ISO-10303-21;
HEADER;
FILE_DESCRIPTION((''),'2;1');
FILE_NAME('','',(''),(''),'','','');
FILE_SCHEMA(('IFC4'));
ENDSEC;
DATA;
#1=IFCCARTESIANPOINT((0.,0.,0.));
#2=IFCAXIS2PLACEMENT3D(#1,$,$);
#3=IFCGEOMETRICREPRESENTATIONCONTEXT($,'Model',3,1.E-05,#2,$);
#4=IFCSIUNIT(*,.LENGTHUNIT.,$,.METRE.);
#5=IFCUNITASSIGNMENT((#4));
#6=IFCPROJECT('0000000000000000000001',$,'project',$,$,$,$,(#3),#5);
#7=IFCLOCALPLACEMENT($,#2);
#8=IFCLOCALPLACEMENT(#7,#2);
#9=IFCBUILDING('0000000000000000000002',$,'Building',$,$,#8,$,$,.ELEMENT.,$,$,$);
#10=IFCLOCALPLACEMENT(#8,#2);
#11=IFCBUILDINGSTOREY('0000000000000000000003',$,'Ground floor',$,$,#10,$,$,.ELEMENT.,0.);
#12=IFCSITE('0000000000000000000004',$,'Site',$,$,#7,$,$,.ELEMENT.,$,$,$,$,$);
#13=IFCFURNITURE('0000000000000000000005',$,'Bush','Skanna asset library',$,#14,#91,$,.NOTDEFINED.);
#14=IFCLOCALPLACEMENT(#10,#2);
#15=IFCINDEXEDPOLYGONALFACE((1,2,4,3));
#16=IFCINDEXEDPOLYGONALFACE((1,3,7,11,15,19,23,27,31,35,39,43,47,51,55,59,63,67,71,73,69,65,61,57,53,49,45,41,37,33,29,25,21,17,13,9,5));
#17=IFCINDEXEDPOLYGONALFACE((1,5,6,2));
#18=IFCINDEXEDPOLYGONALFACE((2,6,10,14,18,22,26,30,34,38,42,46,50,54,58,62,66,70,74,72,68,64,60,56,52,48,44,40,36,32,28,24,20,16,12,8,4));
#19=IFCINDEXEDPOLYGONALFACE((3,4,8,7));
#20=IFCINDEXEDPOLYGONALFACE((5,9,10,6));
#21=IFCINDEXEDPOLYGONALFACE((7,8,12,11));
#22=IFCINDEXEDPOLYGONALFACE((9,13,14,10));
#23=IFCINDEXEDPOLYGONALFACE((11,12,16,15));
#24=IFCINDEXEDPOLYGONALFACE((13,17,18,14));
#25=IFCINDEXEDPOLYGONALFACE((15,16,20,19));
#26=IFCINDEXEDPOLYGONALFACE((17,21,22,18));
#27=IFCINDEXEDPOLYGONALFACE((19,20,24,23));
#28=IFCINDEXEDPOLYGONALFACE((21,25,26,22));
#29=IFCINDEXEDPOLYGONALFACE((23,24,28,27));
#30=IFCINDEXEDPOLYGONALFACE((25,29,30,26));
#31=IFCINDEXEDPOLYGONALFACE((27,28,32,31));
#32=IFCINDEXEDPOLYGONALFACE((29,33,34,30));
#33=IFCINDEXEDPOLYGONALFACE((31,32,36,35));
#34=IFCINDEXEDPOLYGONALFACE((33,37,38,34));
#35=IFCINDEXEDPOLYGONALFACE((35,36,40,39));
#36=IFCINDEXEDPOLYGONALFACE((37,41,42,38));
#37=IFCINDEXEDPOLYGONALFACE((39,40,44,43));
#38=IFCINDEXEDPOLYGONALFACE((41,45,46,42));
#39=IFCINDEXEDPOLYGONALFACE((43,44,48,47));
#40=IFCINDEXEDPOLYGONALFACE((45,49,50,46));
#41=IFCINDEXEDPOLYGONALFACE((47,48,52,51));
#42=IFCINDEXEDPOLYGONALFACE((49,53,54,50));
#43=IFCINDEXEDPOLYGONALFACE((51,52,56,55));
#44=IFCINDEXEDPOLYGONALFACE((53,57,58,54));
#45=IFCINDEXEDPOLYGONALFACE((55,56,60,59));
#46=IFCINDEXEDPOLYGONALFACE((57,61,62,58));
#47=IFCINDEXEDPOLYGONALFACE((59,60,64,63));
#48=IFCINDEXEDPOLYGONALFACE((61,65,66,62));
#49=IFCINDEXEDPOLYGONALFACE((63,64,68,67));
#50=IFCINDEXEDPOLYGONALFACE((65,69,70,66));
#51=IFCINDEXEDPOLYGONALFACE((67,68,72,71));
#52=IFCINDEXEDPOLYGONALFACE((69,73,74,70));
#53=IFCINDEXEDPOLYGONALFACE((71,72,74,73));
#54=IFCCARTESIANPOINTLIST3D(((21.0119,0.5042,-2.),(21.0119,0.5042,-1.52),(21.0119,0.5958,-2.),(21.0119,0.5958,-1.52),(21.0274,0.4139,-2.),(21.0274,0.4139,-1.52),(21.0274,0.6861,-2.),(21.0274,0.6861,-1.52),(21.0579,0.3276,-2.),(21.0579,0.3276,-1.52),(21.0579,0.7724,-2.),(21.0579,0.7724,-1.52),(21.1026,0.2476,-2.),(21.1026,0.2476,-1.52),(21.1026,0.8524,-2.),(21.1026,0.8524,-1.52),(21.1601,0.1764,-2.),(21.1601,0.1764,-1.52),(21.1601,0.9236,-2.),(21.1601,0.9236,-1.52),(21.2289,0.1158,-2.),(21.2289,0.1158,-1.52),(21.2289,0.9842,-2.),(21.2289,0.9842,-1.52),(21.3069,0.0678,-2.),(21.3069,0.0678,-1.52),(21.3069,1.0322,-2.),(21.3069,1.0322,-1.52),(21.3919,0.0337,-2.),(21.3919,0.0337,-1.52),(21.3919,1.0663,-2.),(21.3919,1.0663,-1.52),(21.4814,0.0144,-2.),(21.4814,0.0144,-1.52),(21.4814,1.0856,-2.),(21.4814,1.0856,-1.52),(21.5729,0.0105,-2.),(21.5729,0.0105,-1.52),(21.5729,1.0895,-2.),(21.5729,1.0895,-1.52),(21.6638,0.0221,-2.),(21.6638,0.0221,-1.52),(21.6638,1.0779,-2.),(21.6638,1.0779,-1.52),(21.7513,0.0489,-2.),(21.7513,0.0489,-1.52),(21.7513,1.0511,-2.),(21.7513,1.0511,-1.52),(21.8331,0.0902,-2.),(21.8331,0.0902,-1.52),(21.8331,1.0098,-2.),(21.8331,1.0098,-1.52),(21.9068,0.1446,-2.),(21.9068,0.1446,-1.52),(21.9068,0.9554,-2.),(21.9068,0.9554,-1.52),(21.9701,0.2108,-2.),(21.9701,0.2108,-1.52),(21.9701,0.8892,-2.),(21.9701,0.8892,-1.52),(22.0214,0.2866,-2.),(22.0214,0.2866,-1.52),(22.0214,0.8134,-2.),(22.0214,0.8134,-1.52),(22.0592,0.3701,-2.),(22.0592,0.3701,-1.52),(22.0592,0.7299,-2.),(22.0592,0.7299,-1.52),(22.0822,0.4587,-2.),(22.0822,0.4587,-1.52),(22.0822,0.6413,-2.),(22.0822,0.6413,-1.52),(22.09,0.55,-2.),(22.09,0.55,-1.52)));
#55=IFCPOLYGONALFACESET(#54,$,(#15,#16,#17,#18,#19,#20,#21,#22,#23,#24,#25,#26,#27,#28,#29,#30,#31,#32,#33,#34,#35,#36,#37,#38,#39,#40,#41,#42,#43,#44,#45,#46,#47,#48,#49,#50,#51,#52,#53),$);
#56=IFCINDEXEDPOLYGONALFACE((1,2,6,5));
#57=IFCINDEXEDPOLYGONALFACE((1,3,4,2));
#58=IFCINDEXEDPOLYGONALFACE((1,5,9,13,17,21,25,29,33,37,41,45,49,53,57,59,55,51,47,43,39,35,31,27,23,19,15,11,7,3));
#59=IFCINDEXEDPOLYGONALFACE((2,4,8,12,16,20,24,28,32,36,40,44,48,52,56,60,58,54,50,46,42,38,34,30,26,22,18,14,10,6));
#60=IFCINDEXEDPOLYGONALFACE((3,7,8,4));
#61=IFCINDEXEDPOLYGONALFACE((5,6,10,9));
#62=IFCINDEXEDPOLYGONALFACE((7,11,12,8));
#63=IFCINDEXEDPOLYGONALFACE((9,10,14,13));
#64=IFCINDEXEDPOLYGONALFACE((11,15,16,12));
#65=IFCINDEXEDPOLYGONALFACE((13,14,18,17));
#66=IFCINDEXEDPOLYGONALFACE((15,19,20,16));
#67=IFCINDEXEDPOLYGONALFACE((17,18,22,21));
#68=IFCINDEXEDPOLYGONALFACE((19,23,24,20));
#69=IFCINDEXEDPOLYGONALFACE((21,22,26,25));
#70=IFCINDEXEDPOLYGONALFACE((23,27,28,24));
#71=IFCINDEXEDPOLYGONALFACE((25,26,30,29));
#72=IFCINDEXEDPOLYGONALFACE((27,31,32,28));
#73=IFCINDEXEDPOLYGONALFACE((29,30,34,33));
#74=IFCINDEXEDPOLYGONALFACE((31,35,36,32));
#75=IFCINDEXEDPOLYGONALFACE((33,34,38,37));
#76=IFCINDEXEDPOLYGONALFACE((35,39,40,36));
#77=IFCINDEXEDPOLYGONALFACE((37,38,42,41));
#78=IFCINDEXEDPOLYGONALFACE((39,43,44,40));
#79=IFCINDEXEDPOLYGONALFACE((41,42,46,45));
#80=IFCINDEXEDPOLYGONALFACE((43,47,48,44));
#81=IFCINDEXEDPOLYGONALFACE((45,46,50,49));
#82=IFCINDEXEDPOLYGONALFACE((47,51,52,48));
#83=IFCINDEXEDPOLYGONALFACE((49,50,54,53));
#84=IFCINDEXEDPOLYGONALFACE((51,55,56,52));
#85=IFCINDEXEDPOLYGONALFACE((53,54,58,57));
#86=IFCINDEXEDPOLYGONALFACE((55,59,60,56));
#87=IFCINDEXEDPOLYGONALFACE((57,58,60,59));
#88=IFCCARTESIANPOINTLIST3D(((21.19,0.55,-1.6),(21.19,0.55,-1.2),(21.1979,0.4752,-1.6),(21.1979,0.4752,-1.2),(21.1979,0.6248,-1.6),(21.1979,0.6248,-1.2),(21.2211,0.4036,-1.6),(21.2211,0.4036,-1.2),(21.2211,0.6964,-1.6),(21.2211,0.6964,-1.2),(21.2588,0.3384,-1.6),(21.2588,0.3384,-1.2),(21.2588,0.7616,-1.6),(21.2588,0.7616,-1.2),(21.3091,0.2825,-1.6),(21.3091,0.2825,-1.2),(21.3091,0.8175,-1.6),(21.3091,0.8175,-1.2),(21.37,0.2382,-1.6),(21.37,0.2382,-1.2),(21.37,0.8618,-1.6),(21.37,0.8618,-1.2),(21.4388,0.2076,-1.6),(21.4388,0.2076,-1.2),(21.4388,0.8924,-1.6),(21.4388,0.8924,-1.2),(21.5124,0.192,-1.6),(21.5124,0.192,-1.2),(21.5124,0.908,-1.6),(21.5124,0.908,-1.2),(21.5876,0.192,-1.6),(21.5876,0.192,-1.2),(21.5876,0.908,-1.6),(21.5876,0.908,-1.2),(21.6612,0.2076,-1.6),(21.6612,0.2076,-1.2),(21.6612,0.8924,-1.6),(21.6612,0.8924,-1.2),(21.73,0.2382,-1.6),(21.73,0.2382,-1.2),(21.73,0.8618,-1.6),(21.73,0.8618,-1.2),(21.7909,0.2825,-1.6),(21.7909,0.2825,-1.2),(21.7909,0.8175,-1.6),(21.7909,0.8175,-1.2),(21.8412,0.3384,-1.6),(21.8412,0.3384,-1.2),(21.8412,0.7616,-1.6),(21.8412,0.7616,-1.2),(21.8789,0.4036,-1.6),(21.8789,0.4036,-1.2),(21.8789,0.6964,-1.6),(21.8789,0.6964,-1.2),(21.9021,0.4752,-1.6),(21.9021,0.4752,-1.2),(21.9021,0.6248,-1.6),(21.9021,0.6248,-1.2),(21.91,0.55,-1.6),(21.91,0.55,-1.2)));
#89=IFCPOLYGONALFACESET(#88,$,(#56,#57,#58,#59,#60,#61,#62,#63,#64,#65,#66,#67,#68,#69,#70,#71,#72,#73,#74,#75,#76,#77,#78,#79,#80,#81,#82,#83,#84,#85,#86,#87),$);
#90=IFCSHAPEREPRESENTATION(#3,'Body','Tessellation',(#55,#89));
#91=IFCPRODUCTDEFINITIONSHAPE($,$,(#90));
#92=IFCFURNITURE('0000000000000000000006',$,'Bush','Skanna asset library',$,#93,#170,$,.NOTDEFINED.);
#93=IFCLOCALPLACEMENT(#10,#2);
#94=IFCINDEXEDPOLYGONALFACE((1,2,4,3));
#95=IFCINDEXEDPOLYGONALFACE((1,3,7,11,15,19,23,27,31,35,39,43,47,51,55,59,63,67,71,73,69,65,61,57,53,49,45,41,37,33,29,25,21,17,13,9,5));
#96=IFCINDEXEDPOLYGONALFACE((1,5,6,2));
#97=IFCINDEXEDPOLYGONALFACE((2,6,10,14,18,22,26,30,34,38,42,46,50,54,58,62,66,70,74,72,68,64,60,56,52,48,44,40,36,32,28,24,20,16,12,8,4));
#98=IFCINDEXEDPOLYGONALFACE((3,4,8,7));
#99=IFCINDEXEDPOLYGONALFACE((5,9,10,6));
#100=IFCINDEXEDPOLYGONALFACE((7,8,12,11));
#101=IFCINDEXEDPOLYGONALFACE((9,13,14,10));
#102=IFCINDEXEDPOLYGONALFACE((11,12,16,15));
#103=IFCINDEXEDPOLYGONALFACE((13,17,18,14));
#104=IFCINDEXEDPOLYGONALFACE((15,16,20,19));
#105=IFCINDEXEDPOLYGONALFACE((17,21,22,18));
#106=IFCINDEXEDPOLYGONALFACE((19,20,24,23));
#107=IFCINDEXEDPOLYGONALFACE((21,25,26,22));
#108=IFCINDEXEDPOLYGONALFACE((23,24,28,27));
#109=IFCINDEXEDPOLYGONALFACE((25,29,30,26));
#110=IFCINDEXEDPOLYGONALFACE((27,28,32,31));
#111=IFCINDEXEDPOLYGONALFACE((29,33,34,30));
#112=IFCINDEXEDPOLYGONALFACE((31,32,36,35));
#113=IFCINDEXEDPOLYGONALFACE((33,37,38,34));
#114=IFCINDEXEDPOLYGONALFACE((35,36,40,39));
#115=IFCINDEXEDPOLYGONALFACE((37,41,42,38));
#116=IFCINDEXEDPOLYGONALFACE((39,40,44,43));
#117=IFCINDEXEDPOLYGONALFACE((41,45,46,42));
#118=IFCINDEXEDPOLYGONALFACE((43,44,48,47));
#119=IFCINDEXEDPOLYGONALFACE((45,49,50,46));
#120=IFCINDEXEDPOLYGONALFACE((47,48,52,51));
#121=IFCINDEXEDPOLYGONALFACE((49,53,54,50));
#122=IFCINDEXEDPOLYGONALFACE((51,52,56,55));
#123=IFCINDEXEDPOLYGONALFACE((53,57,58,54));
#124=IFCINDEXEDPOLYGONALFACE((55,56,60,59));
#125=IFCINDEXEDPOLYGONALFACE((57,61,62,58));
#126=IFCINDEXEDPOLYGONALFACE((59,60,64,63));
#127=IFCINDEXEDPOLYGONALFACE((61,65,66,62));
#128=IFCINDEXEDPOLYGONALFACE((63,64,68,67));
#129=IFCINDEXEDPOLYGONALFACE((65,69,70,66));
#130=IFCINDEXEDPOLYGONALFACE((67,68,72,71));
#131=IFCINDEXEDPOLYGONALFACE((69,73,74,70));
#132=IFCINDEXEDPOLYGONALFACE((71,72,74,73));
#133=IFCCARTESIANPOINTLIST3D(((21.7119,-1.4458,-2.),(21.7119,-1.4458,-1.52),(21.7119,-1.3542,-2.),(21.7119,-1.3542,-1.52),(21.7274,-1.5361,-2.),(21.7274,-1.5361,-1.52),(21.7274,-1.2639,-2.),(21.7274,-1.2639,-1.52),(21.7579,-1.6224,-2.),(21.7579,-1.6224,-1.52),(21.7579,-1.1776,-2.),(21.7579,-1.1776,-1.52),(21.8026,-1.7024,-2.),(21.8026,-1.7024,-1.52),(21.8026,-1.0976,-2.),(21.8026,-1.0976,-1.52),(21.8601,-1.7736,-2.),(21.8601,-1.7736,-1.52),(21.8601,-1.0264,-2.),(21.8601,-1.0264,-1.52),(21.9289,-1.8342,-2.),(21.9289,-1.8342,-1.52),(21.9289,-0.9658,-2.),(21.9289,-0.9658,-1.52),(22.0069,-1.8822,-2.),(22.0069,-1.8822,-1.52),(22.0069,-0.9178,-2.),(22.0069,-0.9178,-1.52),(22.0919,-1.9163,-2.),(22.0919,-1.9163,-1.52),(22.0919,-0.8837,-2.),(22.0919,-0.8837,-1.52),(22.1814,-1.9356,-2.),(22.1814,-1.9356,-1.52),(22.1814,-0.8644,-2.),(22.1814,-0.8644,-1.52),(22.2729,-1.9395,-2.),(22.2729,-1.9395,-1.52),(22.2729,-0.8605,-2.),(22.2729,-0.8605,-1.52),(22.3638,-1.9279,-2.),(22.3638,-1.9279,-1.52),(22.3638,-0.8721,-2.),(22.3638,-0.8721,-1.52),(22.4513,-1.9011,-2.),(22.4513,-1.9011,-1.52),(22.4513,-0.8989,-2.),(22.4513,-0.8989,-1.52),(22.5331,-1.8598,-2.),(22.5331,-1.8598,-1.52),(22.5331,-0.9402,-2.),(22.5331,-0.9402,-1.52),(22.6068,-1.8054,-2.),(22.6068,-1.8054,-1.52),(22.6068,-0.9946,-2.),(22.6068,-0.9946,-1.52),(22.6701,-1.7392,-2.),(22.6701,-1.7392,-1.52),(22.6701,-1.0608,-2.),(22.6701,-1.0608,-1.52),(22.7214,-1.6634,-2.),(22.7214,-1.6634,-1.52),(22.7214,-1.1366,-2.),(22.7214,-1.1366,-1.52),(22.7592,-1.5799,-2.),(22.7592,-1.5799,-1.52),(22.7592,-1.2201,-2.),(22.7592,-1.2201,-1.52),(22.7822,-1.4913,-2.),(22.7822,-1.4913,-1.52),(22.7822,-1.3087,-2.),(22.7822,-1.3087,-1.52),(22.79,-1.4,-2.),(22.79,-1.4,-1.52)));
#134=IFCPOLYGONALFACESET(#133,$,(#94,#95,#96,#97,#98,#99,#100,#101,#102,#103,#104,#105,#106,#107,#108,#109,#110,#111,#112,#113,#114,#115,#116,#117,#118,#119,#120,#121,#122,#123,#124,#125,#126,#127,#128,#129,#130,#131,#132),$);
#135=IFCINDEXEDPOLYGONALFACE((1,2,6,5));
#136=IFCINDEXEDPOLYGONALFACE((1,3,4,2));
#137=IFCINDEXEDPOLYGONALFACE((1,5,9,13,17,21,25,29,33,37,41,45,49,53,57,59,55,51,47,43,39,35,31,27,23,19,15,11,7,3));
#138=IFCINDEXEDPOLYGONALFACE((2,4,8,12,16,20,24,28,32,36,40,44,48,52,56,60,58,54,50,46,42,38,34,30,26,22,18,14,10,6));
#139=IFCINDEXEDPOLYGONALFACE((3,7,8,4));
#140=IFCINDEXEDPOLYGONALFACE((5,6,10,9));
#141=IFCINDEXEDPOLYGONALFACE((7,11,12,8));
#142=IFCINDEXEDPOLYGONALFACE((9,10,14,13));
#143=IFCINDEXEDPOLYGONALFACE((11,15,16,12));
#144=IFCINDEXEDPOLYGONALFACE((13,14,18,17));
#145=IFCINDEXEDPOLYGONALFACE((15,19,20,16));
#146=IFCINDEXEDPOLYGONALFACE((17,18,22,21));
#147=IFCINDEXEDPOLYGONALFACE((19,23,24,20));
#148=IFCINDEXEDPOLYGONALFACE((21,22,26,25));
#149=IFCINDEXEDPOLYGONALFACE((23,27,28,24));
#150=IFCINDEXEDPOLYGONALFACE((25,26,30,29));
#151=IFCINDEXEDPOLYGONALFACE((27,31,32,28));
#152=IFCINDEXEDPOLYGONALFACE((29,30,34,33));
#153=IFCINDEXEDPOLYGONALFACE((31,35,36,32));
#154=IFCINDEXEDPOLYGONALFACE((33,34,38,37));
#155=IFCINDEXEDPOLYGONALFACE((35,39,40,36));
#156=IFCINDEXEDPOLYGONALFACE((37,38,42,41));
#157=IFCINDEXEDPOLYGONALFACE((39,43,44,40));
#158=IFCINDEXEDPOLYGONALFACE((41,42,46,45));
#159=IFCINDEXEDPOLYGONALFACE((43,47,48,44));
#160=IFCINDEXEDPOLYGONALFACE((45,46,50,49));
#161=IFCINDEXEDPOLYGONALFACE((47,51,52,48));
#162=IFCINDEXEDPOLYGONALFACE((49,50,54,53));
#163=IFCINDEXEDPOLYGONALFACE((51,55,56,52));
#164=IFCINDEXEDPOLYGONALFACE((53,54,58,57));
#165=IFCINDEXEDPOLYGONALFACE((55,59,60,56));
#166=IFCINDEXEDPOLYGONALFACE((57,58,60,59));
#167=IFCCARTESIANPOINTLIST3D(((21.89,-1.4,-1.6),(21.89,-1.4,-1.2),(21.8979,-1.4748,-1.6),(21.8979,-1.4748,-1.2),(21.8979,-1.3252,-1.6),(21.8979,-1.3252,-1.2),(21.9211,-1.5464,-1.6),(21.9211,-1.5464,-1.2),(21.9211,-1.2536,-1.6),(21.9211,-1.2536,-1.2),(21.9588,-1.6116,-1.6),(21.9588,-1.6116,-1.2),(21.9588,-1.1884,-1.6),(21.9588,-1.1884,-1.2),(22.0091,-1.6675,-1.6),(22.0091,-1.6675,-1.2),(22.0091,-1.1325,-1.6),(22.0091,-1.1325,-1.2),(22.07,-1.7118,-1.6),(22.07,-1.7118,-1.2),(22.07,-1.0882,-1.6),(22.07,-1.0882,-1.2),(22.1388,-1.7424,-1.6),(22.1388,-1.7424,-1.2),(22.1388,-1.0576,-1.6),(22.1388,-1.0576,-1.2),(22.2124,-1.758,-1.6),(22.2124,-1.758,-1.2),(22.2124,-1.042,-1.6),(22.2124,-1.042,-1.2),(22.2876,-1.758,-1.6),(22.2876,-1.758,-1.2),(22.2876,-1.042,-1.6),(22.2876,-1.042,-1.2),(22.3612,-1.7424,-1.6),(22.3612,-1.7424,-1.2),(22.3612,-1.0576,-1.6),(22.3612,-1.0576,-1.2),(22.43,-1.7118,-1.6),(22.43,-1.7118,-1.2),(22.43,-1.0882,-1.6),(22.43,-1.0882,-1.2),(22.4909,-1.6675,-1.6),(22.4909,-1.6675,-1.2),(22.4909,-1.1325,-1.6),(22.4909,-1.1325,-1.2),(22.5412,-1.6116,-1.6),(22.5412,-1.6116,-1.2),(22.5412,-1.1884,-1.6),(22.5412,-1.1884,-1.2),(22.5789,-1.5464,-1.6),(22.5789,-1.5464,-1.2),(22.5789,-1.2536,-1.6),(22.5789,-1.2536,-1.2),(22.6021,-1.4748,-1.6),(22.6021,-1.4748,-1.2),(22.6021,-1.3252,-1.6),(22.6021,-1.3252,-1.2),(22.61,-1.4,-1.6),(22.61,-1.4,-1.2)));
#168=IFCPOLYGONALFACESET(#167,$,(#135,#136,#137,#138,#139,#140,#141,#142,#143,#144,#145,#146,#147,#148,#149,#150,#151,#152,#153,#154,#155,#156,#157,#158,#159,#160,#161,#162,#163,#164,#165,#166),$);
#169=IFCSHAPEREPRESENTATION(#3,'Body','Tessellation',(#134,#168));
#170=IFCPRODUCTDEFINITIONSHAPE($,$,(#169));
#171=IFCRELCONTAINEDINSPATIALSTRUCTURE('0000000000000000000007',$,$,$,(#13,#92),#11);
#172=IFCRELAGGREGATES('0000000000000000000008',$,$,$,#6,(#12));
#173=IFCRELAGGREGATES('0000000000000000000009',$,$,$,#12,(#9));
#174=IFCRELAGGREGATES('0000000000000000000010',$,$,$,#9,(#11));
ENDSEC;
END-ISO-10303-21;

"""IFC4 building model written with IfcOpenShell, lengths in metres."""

from ifc_helpers import new_model, si_unit, frame, origin, origin_2d, place, context, project, spatial, circle, extrude, element, save


model = new_model("IFC4")

# Units and contexts
model_context = context("Model", 3, precision=1e-05, world=origin())
ifc_project = project(units=[si_unit("LENGTHUNIT", "METRE")], contexts=[model_context])

# Site, building, storey
site_placement = place(None, origin())
site = spatial("IfcSite", under=ifc_project, at=site_placement, Name="Site", CompositionType="ELEMENT")
building_placement = place(site_placement, origin())
building = spatial("IfcBuilding", under=site, at=building_placement, Name="Building", CompositionType="ELEMENT")
storey_placement = place(building_placement, origin())
storey = spatial("IfcBuildingStorey", under=building, at=storey_placement, Name="Ground floor", CompositionType="ELEMENT", Elevation=0.0)

# Furniture
for number, where, z_axis, x_axis, name in (
    (1, (21.55, 0.55, -2.0), (0.0, 0.0, 1.0), (1.0, 0.0, 0.0), "Bush"),
    (2, (22.25, -1.4, -2.0), (0.0, 0.0, 1.0), (1.0, 0.0, 0.0), "Bush"),
):
    element("IfcFurniture", number, at=place(storey_placement, frame(where, z_axis=z_axis, x_axis=x_axis)), inside=storey, Name=name, Description="Skanna asset library", PredefinedType="NOTDEFINED", context=model_context, shape_type="SweptSolid", body=[
        extrude(circle(Radius=0.54, at=origin_2d()), origin(), (0.0, 0.0, 1.0), 0.48),
        extrude(circle(Radius=0.36, at=origin_2d()), frame((0.0, 0.0, 0.4)), (0.0, 0.0, 1.0), 0.4),
    ])

save(model, "model.ifc")
